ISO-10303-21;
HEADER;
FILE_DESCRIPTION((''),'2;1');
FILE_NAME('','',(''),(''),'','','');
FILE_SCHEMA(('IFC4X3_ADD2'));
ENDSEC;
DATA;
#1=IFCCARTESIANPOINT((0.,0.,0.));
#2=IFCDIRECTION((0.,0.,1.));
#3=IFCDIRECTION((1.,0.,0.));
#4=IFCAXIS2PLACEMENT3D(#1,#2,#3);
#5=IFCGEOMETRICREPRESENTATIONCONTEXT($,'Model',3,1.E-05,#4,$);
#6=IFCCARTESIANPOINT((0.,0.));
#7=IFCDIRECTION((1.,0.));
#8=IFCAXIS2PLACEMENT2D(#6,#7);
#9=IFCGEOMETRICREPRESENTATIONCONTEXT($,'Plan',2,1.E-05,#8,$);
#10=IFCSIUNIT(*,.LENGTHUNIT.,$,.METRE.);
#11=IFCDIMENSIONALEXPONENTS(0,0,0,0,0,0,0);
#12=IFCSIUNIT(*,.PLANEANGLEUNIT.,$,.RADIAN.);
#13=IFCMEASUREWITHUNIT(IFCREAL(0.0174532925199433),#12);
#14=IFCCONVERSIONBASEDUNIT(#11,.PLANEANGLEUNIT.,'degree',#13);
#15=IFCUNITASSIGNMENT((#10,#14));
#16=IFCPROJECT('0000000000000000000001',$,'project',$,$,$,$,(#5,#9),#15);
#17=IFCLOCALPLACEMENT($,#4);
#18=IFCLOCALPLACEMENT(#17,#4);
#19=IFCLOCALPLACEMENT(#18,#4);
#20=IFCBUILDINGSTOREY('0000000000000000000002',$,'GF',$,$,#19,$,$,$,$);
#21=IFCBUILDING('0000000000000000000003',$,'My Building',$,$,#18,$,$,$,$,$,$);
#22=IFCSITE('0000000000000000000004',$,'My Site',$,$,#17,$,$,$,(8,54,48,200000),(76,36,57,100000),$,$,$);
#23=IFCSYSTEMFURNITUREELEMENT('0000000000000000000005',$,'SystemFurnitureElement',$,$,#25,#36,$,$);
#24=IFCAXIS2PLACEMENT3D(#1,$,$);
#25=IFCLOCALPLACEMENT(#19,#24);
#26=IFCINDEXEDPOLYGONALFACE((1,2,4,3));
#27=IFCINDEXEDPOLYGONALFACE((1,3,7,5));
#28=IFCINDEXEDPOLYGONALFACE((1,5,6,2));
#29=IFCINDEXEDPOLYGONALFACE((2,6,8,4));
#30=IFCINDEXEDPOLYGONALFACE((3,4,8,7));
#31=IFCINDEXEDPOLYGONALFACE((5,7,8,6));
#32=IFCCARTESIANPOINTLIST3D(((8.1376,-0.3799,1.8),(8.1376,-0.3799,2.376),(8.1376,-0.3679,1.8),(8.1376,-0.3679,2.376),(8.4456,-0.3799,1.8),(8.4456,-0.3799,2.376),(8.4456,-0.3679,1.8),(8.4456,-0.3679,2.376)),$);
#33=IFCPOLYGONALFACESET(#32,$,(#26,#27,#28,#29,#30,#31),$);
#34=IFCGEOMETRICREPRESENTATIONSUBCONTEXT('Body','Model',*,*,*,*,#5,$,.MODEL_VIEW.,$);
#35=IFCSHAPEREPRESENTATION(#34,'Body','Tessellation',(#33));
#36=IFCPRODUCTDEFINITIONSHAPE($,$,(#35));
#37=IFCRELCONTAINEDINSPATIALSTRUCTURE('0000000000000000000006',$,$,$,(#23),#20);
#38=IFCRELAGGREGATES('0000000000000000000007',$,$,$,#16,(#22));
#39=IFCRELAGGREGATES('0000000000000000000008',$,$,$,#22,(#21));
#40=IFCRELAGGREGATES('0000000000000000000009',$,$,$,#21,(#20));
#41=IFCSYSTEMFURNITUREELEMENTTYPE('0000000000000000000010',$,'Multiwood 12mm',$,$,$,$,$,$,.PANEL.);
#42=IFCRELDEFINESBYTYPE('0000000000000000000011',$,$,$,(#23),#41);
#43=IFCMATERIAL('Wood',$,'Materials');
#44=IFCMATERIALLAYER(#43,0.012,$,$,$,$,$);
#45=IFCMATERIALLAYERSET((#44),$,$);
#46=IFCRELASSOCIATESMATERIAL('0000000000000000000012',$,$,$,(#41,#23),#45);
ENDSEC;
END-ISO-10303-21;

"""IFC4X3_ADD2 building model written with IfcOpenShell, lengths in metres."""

from ifc_helpers import new_model, entity, si_unit, converted_unit, frame, origin_with_axes, origin_2d_with_axis, place, context, subcontext, project, spatial, line, indexed_curve, outline, extrude, material, layer, layer_set, layer_usage, type_object, element, save


model = new_model("IFC4X3_ADD2")

# Units and contexts
model_context = context("Model", 3, precision=1e-05, world=origin_with_axes())
plan_context = context("Plan", 2, precision=1e-05, world=origin_2d_with_axis())
body_context = subcontext(model_context, "Body", "Model", "MODEL_VIEW")
ifc_project = project(units=[si_unit("LENGTHUNIT", "METRE"), converted_unit("PLANEANGLEUNIT", "degree", entity("IfcReal", 0.0174532925199433), si_unit("PLANEANGLEUNIT", "RADIAN"), dimensions=[0, 0, 0, 0, 0, 0, 0])], contexts=[model_context, plan_context])

# Site, building, storey
site_placement = place(None, origin_with_axes())
site = spatial("IfcSite", under=ifc_project, at=site_placement, Name="My Site", RefLatitude=(8, 54, 48, 200000), RefLongitude=(76, 36, 57, 100000))
building_placement = place(site_placement, origin_with_axes())
building = spatial("IfcBuilding", under=site, at=building_placement, Name="My Building")
storey_placement = place(building_placement, origin_with_axes())
storey = spatial("IfcBuildingStorey", under=building, at=storey_placement, Name="GF")

# System furniture element
ifc_material_1 = material(Name="Wood", Category="Materials")
ifc_layer_1 = layer(ifc_material_1, 0.012)
ifc_layer_set_1 = layer_set([ifc_layer_1])
system_furniture_element_type = type_object("IfcSystemFurnitureElementType", Name="Multiwood 12mm", PredefinedType="PANEL", material=ifc_layer_set_1)
ifc_layer_usage_1 = layer_usage(ifc_layer_set_1, "AXIS2", "POSITIVE", 0.0)
system_furniture_element_1_placement = place(storey_placement, frame((8.4456, -0.3679, 1.8), z_axis=(0.0, 0.0, 1.0), x_axis=(-1.0, 0.0, 0.0)))
element("IfcSystemFurnitureElement", 1, at=system_furniture_element_1_placement, inside=storey, type_object=system_furniture_element_type, material=ifc_layer_usage_1, Name="SystemFurnitureElement", context=body_context, shape_type="SweptSolid", body=[
    extrude(outline(indexed_curve([(0.0, 0.0), (0.0, 0.012), (0.308, 0.012), (0.308, 0.0)], segments=[line(1, 2, 3, 4, 1)])), origin_with_axes(), (0.0, 0.0, 1.0), 0.576),
])

save(model, "model.ifc")
